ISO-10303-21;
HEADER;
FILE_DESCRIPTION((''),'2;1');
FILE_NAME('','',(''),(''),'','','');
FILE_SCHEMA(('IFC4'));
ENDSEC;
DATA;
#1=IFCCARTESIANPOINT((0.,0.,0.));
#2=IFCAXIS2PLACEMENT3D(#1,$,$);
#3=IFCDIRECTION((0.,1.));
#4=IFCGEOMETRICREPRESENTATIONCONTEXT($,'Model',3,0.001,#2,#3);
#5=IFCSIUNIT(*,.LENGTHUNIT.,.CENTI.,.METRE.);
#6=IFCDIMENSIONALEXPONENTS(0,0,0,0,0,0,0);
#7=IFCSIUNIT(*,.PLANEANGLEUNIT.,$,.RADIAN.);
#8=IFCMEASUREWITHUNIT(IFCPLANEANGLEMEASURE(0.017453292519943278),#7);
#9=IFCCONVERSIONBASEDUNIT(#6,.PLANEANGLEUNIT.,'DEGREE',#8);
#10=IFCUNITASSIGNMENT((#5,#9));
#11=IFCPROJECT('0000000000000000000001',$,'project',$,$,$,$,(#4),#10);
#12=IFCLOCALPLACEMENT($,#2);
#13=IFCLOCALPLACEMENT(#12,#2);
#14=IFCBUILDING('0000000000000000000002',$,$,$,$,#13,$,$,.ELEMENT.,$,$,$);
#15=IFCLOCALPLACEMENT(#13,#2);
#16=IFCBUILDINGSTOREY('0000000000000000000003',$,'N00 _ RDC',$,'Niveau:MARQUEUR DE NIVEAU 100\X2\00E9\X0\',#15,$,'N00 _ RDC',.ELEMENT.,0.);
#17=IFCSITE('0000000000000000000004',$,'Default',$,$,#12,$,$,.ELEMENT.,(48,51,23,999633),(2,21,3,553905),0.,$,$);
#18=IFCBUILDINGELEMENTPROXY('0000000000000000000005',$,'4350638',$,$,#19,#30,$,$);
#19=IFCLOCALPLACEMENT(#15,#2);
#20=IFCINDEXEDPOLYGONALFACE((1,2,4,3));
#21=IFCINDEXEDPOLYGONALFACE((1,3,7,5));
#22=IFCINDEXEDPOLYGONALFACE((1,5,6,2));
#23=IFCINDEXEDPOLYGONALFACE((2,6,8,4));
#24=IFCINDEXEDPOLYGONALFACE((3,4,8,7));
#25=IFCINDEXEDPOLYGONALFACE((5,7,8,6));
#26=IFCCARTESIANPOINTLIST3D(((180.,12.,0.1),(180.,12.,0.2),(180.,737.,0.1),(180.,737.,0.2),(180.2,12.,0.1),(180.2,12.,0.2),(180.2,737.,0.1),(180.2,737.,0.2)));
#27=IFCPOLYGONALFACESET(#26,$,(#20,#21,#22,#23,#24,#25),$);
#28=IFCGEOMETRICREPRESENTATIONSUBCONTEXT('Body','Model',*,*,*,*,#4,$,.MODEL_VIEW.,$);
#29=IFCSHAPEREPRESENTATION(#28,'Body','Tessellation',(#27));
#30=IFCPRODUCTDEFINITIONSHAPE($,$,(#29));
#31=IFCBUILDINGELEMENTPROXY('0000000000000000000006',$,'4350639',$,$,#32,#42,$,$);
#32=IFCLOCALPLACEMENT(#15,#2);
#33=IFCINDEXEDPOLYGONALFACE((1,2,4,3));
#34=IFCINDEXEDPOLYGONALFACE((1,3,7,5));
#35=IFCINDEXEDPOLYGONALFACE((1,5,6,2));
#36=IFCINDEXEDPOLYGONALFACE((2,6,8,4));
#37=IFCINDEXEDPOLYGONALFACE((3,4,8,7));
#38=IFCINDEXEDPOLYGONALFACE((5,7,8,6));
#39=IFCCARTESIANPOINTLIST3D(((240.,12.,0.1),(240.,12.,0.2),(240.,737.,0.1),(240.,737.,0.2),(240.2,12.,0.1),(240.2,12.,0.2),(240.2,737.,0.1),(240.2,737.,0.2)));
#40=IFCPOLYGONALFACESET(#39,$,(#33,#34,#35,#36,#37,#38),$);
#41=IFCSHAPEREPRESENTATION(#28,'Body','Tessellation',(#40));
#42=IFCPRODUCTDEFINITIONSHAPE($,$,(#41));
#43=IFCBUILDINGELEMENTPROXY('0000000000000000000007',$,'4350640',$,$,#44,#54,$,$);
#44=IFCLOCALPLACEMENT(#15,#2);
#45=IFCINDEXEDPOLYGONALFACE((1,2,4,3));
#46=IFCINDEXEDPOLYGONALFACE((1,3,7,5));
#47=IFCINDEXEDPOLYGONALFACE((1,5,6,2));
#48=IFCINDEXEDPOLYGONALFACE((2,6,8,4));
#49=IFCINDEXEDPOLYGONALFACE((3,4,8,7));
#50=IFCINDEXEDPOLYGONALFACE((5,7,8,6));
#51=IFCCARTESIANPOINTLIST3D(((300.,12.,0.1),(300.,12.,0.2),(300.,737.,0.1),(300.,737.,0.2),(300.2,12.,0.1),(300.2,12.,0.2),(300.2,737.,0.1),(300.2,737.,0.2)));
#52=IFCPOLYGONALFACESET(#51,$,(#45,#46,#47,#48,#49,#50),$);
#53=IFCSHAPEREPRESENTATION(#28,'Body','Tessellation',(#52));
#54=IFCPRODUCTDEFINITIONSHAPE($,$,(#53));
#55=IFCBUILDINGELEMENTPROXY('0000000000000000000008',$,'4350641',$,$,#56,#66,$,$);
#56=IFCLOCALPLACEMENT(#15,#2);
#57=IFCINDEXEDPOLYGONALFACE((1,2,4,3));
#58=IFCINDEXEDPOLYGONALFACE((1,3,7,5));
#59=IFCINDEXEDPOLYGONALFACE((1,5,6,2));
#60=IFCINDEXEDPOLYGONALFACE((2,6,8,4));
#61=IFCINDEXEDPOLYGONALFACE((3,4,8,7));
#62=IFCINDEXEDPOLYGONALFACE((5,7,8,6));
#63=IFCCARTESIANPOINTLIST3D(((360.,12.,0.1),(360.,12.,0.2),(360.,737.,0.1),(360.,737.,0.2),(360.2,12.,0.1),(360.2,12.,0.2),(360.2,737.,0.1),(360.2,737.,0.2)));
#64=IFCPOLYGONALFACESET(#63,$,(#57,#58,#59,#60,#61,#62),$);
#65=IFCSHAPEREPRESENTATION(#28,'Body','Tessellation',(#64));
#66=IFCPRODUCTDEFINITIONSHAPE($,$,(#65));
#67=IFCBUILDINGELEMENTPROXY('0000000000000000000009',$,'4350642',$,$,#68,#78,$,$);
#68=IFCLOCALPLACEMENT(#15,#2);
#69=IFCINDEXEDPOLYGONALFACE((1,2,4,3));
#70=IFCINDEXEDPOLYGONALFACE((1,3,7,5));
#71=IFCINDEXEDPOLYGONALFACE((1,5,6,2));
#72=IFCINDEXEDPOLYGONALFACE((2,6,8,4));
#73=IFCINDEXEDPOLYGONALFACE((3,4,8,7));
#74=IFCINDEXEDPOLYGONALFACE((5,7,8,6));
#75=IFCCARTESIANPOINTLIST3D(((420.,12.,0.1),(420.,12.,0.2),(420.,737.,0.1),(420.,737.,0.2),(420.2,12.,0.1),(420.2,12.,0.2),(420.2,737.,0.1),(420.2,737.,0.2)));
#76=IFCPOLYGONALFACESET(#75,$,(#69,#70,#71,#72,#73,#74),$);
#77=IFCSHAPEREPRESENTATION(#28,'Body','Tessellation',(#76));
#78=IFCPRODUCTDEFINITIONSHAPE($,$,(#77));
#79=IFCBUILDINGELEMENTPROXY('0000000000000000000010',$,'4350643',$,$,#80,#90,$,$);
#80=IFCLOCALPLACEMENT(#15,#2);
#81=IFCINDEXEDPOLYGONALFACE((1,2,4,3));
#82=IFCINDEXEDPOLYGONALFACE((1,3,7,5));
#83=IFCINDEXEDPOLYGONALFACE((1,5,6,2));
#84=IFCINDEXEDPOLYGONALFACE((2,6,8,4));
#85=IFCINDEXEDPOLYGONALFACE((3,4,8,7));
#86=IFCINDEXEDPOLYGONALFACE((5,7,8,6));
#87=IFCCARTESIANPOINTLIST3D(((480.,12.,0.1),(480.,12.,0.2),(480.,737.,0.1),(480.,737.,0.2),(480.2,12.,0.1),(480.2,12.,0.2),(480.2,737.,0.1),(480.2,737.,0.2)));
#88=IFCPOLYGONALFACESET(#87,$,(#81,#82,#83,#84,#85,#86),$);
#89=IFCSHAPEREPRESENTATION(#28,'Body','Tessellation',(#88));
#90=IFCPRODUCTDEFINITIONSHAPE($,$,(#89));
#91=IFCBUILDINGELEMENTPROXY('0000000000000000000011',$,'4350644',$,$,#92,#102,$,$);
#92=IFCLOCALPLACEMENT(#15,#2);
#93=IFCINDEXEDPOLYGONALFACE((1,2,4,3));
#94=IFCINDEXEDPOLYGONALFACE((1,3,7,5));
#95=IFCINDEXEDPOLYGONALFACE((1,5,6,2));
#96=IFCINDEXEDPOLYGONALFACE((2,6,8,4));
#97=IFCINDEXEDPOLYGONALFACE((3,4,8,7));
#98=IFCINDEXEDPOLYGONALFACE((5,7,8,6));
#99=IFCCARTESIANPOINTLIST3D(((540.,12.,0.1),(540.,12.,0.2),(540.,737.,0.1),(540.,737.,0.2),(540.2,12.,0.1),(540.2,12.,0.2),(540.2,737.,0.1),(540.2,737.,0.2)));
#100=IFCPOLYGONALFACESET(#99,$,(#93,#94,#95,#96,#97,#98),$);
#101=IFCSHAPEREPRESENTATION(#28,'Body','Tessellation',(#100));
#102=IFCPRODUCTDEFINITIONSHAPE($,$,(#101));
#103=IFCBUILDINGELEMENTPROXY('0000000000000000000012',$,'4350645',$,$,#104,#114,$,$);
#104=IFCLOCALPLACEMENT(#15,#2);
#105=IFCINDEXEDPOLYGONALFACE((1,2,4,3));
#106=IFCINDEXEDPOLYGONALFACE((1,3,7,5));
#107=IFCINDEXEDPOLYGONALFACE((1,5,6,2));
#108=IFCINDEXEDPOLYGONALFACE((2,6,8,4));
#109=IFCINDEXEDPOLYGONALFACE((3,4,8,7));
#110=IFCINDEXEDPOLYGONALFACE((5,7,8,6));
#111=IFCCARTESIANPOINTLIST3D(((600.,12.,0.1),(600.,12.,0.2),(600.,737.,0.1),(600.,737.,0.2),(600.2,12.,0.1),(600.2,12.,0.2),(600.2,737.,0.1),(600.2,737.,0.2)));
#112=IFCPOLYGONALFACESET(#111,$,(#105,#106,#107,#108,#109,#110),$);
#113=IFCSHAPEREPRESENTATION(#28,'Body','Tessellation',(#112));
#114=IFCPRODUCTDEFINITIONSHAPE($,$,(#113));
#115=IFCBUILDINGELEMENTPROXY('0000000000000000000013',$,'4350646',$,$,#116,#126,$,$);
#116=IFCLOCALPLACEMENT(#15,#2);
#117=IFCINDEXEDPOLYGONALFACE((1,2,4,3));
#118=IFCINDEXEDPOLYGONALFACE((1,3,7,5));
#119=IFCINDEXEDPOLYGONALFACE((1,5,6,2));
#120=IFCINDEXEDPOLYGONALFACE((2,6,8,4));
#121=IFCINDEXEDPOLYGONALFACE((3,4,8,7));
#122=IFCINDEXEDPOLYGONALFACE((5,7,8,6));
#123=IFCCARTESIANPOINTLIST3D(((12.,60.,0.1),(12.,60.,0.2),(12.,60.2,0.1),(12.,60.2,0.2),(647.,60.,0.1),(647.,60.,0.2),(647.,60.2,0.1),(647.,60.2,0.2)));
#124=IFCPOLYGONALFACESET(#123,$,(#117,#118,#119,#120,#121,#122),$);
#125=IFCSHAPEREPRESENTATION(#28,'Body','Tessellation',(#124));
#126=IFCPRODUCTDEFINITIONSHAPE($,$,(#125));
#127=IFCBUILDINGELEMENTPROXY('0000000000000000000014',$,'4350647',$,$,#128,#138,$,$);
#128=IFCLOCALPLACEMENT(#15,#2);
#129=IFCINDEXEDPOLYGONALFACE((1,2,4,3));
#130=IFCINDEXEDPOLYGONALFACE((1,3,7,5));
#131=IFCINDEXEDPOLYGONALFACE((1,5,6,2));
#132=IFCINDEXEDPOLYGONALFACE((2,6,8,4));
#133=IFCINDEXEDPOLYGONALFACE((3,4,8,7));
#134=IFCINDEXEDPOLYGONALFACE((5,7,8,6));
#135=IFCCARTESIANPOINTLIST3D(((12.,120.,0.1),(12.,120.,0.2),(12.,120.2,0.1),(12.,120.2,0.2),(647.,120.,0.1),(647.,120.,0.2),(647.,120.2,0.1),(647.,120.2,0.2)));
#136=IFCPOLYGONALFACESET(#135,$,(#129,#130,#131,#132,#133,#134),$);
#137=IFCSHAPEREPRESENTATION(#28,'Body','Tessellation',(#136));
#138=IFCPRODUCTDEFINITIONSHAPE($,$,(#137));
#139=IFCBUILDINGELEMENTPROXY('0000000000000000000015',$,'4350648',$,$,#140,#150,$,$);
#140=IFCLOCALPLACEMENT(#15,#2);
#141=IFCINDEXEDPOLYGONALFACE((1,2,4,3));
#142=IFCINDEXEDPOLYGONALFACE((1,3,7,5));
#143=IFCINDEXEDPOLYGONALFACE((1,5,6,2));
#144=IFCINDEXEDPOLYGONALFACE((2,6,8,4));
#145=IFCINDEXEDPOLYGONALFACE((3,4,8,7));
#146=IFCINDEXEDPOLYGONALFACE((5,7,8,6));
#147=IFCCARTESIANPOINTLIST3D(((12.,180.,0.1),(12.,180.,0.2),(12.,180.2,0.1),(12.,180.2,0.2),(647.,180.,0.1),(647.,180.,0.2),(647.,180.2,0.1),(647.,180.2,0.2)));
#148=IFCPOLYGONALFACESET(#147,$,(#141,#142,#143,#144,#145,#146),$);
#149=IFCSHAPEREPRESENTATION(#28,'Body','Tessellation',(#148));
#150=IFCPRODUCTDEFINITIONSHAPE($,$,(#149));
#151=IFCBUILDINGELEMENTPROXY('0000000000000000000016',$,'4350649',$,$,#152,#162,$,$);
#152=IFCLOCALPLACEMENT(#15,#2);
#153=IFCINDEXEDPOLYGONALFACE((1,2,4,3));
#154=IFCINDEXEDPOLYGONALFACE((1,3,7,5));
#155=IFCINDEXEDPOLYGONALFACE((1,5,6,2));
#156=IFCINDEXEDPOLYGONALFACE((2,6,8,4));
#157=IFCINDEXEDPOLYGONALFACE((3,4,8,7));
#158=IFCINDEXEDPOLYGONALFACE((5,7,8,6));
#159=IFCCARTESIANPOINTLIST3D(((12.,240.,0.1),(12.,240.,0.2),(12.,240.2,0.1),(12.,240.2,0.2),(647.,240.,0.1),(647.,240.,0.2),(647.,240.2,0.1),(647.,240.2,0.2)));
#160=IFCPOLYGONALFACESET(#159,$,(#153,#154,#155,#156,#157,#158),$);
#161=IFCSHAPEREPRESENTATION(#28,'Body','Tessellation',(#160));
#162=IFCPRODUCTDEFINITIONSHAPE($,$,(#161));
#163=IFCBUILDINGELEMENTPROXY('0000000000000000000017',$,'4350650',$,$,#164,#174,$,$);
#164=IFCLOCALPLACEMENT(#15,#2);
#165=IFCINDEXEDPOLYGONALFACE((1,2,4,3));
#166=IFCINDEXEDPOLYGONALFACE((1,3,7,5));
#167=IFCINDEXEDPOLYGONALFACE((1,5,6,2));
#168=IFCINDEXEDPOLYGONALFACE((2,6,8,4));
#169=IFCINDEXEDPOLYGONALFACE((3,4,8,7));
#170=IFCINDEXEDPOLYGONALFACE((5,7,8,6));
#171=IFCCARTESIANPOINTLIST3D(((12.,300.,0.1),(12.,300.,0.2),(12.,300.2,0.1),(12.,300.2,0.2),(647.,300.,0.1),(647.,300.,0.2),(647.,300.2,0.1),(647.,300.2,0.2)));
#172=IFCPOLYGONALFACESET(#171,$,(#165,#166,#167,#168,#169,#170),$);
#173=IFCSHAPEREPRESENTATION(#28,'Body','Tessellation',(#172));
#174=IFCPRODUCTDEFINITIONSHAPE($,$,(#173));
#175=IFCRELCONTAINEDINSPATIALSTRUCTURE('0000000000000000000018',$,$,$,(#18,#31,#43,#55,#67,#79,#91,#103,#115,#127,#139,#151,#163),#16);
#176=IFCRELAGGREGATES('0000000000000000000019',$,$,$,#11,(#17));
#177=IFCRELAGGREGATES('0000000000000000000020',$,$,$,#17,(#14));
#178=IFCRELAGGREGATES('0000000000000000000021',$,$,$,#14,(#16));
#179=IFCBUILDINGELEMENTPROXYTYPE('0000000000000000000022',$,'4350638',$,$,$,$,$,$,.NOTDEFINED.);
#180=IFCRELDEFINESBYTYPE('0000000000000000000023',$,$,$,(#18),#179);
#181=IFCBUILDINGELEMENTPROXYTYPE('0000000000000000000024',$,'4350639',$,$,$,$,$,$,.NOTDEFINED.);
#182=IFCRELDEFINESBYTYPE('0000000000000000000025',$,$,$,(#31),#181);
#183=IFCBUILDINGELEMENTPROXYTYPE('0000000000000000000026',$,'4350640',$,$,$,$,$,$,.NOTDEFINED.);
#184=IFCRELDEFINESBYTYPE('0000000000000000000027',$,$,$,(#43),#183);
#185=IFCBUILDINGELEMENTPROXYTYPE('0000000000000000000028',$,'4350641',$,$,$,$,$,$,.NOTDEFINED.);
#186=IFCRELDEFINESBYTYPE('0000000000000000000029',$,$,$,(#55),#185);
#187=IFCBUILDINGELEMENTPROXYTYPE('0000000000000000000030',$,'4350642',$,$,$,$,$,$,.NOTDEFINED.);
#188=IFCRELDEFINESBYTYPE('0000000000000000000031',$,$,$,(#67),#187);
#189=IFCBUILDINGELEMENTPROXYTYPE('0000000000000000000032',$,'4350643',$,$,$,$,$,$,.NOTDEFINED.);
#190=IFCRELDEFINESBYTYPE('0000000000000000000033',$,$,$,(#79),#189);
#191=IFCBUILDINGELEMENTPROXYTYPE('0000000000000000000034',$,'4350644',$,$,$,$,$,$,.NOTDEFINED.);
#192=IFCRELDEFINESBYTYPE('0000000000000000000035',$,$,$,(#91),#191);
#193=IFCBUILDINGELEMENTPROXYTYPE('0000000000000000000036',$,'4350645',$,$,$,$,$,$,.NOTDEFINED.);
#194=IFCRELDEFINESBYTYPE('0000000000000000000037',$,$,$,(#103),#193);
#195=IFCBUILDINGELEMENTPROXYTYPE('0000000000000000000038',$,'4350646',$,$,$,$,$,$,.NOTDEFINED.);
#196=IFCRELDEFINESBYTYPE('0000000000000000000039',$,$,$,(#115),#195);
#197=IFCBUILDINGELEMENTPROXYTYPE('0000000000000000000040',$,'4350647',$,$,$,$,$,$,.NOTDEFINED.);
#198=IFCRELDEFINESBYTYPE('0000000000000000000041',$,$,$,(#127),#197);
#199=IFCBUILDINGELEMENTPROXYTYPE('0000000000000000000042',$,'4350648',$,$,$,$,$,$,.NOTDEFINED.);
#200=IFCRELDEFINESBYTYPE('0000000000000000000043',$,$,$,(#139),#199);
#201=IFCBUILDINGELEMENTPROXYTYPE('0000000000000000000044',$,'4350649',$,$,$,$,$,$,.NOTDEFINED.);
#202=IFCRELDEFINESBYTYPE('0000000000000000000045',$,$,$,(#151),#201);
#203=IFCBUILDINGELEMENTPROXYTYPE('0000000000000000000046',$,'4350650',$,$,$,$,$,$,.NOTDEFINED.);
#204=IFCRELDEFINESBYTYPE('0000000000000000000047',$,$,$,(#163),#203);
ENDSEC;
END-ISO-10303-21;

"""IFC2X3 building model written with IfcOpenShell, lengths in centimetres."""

from ifc_helpers import new_model, entity, si_unit, converted_unit, direction, frame, frame_2d, origin, origin_2d_with_axis, place, context, subcontext, project, spatial, rectangle, extrude, type_object, element, save


model = new_model("IFC2X3")

# Units and contexts
model_context = context("Model", 3, precision=0.001, world=origin(), true_north=direction((0.0, 1.0)))
body_context = subcontext(model_context, "Body", "Model", "MODEL_VIEW")
ifc_project = project(units=[si_unit("LENGTHUNIT", "METRE", prefix="CENTI"), converted_unit("PLANEANGLEUNIT", "DEGREE", entity("IfcPlaneAngleMeasure", 0.017453292519943278), si_unit("PLANEANGLEUNIT", "RADIAN"), dimensions=[0, 0, 0, 0, 0, 0, 0])], contexts=[model_context])

# Site, building, storey
site_placement = place(None, origin())
site = spatial("IfcSite", under=ifc_project, at=site_placement, Name="Default", CompositionType="ELEMENT", RefLatitude=(48, 51, 23, 999633), RefLongitude=(2, 21, 3, 553905), RefElevation=0.0)
building_placement = place(site_placement, origin())
building = spatial("IfcBuilding", under=site, at=building_placement, CompositionType="ELEMENT")
storey_placement = place(building_placement, origin())
storey = spatial("IfcBuildingStorey", under=building, at=storey_placement, Name="N00 _ RDC", ObjectType="Niveau:MARQUEUR DE NIVEAU 100é", LongName="N00 _ RDC", CompositionType="ELEMENT", Elevation=0.0)

# Building element proxies
building_element_proxy_type_1 = type_object("IfcBuildingElementProxyType", Name="4350638", PredefinedType="NOTDEFINED")
proxy_1_placement = place(storey_placement, origin())
element("IfcBuildingElementProxy", 1, at=proxy_1_placement, inside=storey, type_object=building_element_proxy_type_1, Name="4350638", context=body_context, shape_type="SweptSolid", body=[
    extrude(rectangle(XDim=0.2, YDim=725.0, at=origin_2d_with_axis()), frame((180.1, 374.5, 0.1)), (0.0, 0.0, 1.0), 0.1),
])
building_element_proxy_type_2 = type_object("IfcBuildingElementProxyType", Name="4350639", PredefinedType="NOTDEFINED")
proxy_2_placement = place(storey_placement, origin())
element("IfcBuildingElementProxy", 2, at=proxy_2_placement, inside=storey, type_object=building_element_proxy_type_2, Name="4350639", context=body_context, shape_type="SweptSolid", body=[
    extrude(rectangle(XDim=0.2, YDim=725.0, at=frame_2d((0.0, 0.0), x_axis=(1.0, 0.0))), frame((240.1, 374.5, 0.1)), (0.0, 0.0, 1.0), 0.1),
])
building_element_proxy_type_3 = type_object("IfcBuildingElementProxyType", Name="4350640", PredefinedType="NOTDEFINED")
proxy_3_placement = place(storey_placement, origin())
element("IfcBuildingElementProxy", 3, at=proxy_3_placement, inside=storey, type_object=building_element_proxy_type_3, Name="4350640", context=body_context, shape_type="SweptSolid", body=[
    extrude(rectangle(XDim=0.2, YDim=725.0, at=origin_2d_with_axis()), frame((300.1, 374.5, 0.1)), (0.0, 0.0, 1.0), 0.1),
])
building_element_proxy_type_4 = type_object("IfcBuildingElementProxyType", Name="4350641", PredefinedType="NOTDEFINED")
proxy_4_placement = place(storey_placement, origin())
element("IfcBuildingElementProxy", 4, at=proxy_4_placement, inside=storey, type_object=building_element_proxy_type_4, Name="4350641", context=body_context, shape_type="SweptSolid", body=[
    extrude(rectangle(XDim=0.2, YDim=725.0, at=origin_2d_with_axis()), frame((360.1, 374.5, 0.1)), (0.0, 0.0, 1.0), 0.1),
])
building_element_proxy_type_5 = type_object("IfcBuildingElementProxyType", Name="4350642", PredefinedType="NOTDEFINED")
proxy_5_placement = place(storey_placement, origin())
element("IfcBuildingElementProxy", 5, at=proxy_5_placement, inside=storey, type_object=building_element_proxy_type_5, Name="4350642", context=body_context, shape_type="SweptSolid", body=[
    extrude(rectangle(XDim=0.2, YDim=725.0, at=origin_2d_with_axis()), frame((420.1, 374.5, 0.1)), (0.0, 0.0, 1.0), 0.1),
])
building_element_proxy_type_6 = type_object("IfcBuildingElementProxyType", Name="4350643", PredefinedType="NOTDEFINED")
proxy_6_placement = place(storey_placement, origin())
element("IfcBuildingElementProxy", 6, at=proxy_6_placement, inside=storey, type_object=building_element_proxy_type_6, Name="4350643", context=body_context, shape_type="SweptSolid", body=[
    extrude(rectangle(XDim=0.2, YDim=725.0, at=origin_2d_with_axis()), frame((480.1, 374.5, 0.1)), (0.0, 0.0, 1.0), 0.1),
])
building_element_proxy_type_7 = type_object("IfcBuildingElementProxyType", Name="4350644", PredefinedType="NOTDEFINED")
proxy_7_placement = place(storey_placement, origin())
element("IfcBuildingElementProxy", 7, at=proxy_7_placement, inside=storey, type_object=building_element_proxy_type_7, Name="4350644", context=body_context, shape_type="SweptSolid", body=[
    extrude(rectangle(XDim=0.2, YDim=725.0, at=origin_2d_with_axis()), frame((540.1, 374.5, 0.1)), (0.0, 0.0, 1.0), 0.1),
])
building_element_proxy_type_8 = type_object("IfcBuildingElementProxyType", Name="4350645", PredefinedType="NOTDEFINED")
proxy_8_placement = place(storey_placement, origin())
element("IfcBuildingElementProxy", 8, at=proxy_8_placement, inside=storey, type_object=building_element_proxy_type_8, Name="4350645", context=body_context, shape_type="SweptSolid", body=[
    extrude(rectangle(XDim=0.2, YDim=725.0, at=origin_2d_with_axis()), frame((600.1, 374.5, 0.1)), (0.0, 0.0, 1.0), 0.1),
])
building_element_proxy_type_9 = type_object("IfcBuildingElementProxyType", Name="4350646", PredefinedType="NOTDEFINED")
proxy_9_placement = place(storey_placement, origin())
element("IfcBuildingElementProxy", 9, at=proxy_9_placement, inside=storey, type_object=building_element_proxy_type_9, Name="4350646", context=body_context, shape_type="SweptSolid", body=[
    extrude(rectangle(XDim=635.0, YDim=0.2, at=frame_2d((0.0, 0.0), x_axis=(1.0, 0.0))), frame((329.5, 60.1, 0.1)), (0.0, 0.0, 1.0), 0.1),
])
building_element_proxy_type_10 = type_object("IfcBuildingElementProxyType", Name="4350647", PredefinedType="NOTDEFINED")
proxy_10_placement = place(storey_placement, origin())
element("IfcBuildingElementProxy", 10, at=proxy_10_placement, inside=storey, type_object=building_element_proxy_type_10, Name="4350647", context=body_context, shape_type="SweptSolid", body=[
    extrude(rectangle(XDim=635.0, YDim=0.2, at=frame_2d((0.0, 0.0), x_axis=(1.0, 0.0))), frame((329.5, 120.1, 0.1)), (0.0, 0.0, 1.0), 0.1),
])
building_element_proxy_type_11 = type_object("IfcBuildingElementProxyType", Name="4350648", PredefinedType="NOTDEFINED")
proxy_11_placement = place(storey_placement, origin())
element("IfcBuildingElementProxy", 11, at=proxy_11_placement, inside=storey, type_object=building_element_proxy_type_11, Name="4350648", context=body_context, shape_type="SweptSolid", body=[
    extrude(rectangle(XDim=635.0, YDim=0.2, at=frame_2d((0.0, 0.0), x_axis=(1.0, 0.0))), frame((329.5, 180.1, 0.1)), (0.0, 0.0, 1.0), 0.1),
])
building_element_proxy_type_12 = type_object("IfcBuildingElementProxyType", Name="4350649", PredefinedType="NOTDEFINED")
proxy_12_placement = place(storey_placement, origin())
element("IfcBuildingElementProxy", 12, at=proxy_12_placement, inside=storey, type_object=building_element_proxy_type_12, Name="4350649", context=body_context, shape_type="SweptSolid", body=[
    extrude(rectangle(XDim=635.0, YDim=0.2, at=frame_2d((0.0, 0.0), x_axis=(1.0, 0.0))), frame((329.5, 240.1, 0.1)), (0.0, 0.0, 1.0), 0.1),
])
building_element_proxy_type_13 = type_object("IfcBuildingElementProxyType", Name="4350650", PredefinedType="NOTDEFINED")
proxy_13_placement = place(storey_placement, origin())
element("IfcBuildingElementProxy", 13, at=proxy_13_placement, inside=storey, type_object=building_element_proxy_type_13, Name="4350650", context=body_context, shape_type="SweptSolid", body=[
    extrude(rectangle(XDim=635.0, YDim=0.2, at=frame_2d((0.0, 0.0), x_axis=(1.0, 0.0))), frame((329.5, 300.1, 0.1)), (0.0, 0.0, 1.0), 0.1),
])

save(model, "model.ifc")
